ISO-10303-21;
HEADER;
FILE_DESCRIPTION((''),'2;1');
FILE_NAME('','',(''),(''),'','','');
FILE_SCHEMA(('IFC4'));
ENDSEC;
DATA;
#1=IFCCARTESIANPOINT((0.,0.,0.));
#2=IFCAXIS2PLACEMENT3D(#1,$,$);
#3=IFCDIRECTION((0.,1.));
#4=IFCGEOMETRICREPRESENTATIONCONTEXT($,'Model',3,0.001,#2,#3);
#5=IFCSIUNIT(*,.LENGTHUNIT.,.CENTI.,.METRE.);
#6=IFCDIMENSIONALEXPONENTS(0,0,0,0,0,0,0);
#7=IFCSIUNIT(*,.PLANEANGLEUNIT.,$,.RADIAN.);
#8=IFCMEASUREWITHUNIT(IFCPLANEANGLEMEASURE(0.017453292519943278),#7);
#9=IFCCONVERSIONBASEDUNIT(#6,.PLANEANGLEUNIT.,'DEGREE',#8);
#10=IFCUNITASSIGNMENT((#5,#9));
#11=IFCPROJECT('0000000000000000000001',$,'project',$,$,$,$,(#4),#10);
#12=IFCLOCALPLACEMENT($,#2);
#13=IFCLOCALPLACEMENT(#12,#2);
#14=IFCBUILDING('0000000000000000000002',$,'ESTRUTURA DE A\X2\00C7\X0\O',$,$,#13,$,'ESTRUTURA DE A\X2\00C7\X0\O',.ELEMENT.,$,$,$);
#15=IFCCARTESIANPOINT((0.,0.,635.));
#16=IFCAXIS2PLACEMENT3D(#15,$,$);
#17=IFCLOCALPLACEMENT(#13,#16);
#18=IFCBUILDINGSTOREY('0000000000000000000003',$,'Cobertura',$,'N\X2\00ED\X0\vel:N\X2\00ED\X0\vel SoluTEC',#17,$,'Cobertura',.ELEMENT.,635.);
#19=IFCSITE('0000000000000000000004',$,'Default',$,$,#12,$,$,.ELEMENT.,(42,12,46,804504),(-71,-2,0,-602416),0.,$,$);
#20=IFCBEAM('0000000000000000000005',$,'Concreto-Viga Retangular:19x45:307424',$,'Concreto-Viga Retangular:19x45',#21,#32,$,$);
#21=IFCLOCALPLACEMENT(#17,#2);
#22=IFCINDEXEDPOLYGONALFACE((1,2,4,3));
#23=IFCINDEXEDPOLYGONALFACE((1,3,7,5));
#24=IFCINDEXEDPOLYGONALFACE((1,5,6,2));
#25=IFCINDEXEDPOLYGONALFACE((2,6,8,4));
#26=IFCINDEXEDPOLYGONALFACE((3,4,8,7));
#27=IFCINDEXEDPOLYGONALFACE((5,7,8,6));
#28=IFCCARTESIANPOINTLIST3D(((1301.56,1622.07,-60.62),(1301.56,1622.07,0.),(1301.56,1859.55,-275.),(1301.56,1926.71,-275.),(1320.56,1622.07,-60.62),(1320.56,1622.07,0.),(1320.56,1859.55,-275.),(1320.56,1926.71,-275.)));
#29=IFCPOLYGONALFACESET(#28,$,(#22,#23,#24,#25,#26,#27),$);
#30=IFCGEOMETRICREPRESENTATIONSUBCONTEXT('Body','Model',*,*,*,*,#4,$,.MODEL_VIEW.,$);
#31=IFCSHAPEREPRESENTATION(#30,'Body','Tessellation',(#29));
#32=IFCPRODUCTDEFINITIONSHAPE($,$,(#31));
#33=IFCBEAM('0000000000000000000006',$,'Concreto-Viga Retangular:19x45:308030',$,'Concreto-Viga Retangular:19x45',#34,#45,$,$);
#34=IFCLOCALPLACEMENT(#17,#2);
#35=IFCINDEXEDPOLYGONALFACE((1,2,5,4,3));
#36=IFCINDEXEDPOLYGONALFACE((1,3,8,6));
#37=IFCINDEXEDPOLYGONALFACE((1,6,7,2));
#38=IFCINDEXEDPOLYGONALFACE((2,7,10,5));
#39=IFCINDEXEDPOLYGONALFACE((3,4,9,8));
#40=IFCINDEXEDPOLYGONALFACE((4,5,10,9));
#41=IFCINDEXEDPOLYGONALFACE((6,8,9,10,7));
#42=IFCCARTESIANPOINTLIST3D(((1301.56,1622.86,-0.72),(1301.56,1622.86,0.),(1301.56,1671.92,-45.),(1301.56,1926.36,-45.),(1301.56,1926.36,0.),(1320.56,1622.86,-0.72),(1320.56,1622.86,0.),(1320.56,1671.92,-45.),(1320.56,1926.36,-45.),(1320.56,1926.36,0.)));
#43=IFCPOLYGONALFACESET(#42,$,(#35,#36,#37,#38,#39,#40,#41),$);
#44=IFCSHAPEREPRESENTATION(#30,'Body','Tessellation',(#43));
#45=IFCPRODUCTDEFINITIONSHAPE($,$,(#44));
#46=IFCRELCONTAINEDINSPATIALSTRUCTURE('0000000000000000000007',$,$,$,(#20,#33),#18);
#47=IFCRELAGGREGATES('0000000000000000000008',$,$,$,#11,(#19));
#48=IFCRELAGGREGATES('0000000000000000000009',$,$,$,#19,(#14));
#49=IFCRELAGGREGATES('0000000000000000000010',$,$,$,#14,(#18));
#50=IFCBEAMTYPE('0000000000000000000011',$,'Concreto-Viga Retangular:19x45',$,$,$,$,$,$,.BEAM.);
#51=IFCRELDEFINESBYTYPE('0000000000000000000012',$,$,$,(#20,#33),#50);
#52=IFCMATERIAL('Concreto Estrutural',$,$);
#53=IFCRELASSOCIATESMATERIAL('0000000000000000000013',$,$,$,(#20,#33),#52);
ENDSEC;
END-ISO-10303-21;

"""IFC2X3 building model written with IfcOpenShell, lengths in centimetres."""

from ifc_helpers import new_model, entity, si_unit, converted_unit, direction, frame, frame_2d, origin, place, context, subcontext, project, spatial, rectangle, extrude, clip, halfspace, material, type_object, element, save


model = new_model("IFC2X3")

# Units and contexts
model_context = context("Model", 3, precision=0.001, world=origin(), true_north=direction((0.0, 1.0)))
body_context = subcontext(model_context, "Body", "Model", "MODEL_VIEW")
ifc_project = project(units=[si_unit("LENGTHUNIT", "METRE", prefix="CENTI"), converted_unit("PLANEANGLEUNIT", "DEGREE", entity("IfcPlaneAngleMeasure", 0.017453292519943278), si_unit("PLANEANGLEUNIT", "RADIAN"), dimensions=[0, 0, 0, 0, 0, 0, 0])], contexts=[model_context])

# Site, building, storey
site_placement = place(None, origin())
site = spatial("IfcSite", under=ifc_project, at=site_placement, Name="Default", CompositionType="ELEMENT", RefLatitude=(42, 12, 46, 804504), RefLongitude=(-71, -2, 0, -602416), RefElevation=0.0)
building_placement = place(site_placement, origin())
building = spatial("IfcBuilding", under=site, at=building_placement, Name="ESTRUTURA DE AÇO", LongName="ESTRUTURA DE AÇO", CompositionType="ELEMENT")
storey_placement = place(building_placement, frame((0.0, 0.0, 635.0)))
storey = spatial("IfcBuildingStorey", under=building, at=storey_placement, Name="Cobertura", ObjectType="Nível:Nível SoluTEC", LongName="Cobertura", CompositionType="ELEMENT", Elevation=635.0)

# Beams
ifc_material = material(Name="Concreto Estrutural")
beam_type = type_object("IfcBeamType", Name="Concreto-Viga Retangular:19x45", PredefinedType="BEAM")
beam_1_placement = place(storey_placement, frame((1311.06, 1622.07, 0.0), z_axis=(0.0, 0.670074, 0.742295), x_axis=(0.0, 0.742295, -0.670074)))
element("IfcBeam", 1, at=beam_1_placement, inside=storey, type_object=beam_type, material=ifc_material, Name="Concreto-Viga Retangular:19x45:307424", ObjectType="Concreto-Viga Retangular:19x45", context=body_context, shape_type="SweptSolid", body=[
    clip(clip(extrude(rectangle(XDim=45.0, YDim=19.0, at=frame_2d((0.0, 0.0), x_axis=(1.0, 0.0))), frame((0.0, 0.0, -22.5), z_axis=(1.0, 0.0, 0.0), x_axis=(0.0, 0.0, -1.0)), (0.0, 0.0, 1.0), 410.4), halfspace(frame((409.46, 9.5, -0.85), z_axis=(0.670074, 0.0, -0.742295), x_axis=(-0.742295, 0.0, -0.670074)), False)), halfspace(frame((0.0, 0.0, 0.0), z_axis=(-0.742295, 0.0, -0.670074), x_axis=(0.670074, 0.0, -0.742295)), False)),
])
beam_2_placement = place(storey_placement, frame((1311.06, 1622.86, 0.0), z_axis=(0.0, 0.0, 1.0), x_axis=(0.0, 1.0, 0.0)))
element("IfcBeam", 2, at=beam_2_placement, inside=storey, type_object=beam_type, material=ifc_material, Name="Concreto-Viga Retangular:19x45:308030", ObjectType="Concreto-Viga Retangular:19x45", context=body_context, shape_type="SweptSolid", body=[
    clip(extrude(rectangle(XDim=45.0, YDim=19.0, at=frame_2d((0.0, 0.0), x_axis=(0.0, 1.0))), frame((0.0, 0.0, -22.5), z_axis=(1.0, 0.0, 0.0), x_axis=(0.0, 1.0, 0.0)), (0.0, 0.0, 1.0), 303.5), halfspace(frame((302.9, 9.5, -274.15), z_axis=(-0.670074, 0.0, -0.742295), x_axis=(-0.742295, 0.0, 0.670074)), False)),
])

save(model, "model.ifc")
